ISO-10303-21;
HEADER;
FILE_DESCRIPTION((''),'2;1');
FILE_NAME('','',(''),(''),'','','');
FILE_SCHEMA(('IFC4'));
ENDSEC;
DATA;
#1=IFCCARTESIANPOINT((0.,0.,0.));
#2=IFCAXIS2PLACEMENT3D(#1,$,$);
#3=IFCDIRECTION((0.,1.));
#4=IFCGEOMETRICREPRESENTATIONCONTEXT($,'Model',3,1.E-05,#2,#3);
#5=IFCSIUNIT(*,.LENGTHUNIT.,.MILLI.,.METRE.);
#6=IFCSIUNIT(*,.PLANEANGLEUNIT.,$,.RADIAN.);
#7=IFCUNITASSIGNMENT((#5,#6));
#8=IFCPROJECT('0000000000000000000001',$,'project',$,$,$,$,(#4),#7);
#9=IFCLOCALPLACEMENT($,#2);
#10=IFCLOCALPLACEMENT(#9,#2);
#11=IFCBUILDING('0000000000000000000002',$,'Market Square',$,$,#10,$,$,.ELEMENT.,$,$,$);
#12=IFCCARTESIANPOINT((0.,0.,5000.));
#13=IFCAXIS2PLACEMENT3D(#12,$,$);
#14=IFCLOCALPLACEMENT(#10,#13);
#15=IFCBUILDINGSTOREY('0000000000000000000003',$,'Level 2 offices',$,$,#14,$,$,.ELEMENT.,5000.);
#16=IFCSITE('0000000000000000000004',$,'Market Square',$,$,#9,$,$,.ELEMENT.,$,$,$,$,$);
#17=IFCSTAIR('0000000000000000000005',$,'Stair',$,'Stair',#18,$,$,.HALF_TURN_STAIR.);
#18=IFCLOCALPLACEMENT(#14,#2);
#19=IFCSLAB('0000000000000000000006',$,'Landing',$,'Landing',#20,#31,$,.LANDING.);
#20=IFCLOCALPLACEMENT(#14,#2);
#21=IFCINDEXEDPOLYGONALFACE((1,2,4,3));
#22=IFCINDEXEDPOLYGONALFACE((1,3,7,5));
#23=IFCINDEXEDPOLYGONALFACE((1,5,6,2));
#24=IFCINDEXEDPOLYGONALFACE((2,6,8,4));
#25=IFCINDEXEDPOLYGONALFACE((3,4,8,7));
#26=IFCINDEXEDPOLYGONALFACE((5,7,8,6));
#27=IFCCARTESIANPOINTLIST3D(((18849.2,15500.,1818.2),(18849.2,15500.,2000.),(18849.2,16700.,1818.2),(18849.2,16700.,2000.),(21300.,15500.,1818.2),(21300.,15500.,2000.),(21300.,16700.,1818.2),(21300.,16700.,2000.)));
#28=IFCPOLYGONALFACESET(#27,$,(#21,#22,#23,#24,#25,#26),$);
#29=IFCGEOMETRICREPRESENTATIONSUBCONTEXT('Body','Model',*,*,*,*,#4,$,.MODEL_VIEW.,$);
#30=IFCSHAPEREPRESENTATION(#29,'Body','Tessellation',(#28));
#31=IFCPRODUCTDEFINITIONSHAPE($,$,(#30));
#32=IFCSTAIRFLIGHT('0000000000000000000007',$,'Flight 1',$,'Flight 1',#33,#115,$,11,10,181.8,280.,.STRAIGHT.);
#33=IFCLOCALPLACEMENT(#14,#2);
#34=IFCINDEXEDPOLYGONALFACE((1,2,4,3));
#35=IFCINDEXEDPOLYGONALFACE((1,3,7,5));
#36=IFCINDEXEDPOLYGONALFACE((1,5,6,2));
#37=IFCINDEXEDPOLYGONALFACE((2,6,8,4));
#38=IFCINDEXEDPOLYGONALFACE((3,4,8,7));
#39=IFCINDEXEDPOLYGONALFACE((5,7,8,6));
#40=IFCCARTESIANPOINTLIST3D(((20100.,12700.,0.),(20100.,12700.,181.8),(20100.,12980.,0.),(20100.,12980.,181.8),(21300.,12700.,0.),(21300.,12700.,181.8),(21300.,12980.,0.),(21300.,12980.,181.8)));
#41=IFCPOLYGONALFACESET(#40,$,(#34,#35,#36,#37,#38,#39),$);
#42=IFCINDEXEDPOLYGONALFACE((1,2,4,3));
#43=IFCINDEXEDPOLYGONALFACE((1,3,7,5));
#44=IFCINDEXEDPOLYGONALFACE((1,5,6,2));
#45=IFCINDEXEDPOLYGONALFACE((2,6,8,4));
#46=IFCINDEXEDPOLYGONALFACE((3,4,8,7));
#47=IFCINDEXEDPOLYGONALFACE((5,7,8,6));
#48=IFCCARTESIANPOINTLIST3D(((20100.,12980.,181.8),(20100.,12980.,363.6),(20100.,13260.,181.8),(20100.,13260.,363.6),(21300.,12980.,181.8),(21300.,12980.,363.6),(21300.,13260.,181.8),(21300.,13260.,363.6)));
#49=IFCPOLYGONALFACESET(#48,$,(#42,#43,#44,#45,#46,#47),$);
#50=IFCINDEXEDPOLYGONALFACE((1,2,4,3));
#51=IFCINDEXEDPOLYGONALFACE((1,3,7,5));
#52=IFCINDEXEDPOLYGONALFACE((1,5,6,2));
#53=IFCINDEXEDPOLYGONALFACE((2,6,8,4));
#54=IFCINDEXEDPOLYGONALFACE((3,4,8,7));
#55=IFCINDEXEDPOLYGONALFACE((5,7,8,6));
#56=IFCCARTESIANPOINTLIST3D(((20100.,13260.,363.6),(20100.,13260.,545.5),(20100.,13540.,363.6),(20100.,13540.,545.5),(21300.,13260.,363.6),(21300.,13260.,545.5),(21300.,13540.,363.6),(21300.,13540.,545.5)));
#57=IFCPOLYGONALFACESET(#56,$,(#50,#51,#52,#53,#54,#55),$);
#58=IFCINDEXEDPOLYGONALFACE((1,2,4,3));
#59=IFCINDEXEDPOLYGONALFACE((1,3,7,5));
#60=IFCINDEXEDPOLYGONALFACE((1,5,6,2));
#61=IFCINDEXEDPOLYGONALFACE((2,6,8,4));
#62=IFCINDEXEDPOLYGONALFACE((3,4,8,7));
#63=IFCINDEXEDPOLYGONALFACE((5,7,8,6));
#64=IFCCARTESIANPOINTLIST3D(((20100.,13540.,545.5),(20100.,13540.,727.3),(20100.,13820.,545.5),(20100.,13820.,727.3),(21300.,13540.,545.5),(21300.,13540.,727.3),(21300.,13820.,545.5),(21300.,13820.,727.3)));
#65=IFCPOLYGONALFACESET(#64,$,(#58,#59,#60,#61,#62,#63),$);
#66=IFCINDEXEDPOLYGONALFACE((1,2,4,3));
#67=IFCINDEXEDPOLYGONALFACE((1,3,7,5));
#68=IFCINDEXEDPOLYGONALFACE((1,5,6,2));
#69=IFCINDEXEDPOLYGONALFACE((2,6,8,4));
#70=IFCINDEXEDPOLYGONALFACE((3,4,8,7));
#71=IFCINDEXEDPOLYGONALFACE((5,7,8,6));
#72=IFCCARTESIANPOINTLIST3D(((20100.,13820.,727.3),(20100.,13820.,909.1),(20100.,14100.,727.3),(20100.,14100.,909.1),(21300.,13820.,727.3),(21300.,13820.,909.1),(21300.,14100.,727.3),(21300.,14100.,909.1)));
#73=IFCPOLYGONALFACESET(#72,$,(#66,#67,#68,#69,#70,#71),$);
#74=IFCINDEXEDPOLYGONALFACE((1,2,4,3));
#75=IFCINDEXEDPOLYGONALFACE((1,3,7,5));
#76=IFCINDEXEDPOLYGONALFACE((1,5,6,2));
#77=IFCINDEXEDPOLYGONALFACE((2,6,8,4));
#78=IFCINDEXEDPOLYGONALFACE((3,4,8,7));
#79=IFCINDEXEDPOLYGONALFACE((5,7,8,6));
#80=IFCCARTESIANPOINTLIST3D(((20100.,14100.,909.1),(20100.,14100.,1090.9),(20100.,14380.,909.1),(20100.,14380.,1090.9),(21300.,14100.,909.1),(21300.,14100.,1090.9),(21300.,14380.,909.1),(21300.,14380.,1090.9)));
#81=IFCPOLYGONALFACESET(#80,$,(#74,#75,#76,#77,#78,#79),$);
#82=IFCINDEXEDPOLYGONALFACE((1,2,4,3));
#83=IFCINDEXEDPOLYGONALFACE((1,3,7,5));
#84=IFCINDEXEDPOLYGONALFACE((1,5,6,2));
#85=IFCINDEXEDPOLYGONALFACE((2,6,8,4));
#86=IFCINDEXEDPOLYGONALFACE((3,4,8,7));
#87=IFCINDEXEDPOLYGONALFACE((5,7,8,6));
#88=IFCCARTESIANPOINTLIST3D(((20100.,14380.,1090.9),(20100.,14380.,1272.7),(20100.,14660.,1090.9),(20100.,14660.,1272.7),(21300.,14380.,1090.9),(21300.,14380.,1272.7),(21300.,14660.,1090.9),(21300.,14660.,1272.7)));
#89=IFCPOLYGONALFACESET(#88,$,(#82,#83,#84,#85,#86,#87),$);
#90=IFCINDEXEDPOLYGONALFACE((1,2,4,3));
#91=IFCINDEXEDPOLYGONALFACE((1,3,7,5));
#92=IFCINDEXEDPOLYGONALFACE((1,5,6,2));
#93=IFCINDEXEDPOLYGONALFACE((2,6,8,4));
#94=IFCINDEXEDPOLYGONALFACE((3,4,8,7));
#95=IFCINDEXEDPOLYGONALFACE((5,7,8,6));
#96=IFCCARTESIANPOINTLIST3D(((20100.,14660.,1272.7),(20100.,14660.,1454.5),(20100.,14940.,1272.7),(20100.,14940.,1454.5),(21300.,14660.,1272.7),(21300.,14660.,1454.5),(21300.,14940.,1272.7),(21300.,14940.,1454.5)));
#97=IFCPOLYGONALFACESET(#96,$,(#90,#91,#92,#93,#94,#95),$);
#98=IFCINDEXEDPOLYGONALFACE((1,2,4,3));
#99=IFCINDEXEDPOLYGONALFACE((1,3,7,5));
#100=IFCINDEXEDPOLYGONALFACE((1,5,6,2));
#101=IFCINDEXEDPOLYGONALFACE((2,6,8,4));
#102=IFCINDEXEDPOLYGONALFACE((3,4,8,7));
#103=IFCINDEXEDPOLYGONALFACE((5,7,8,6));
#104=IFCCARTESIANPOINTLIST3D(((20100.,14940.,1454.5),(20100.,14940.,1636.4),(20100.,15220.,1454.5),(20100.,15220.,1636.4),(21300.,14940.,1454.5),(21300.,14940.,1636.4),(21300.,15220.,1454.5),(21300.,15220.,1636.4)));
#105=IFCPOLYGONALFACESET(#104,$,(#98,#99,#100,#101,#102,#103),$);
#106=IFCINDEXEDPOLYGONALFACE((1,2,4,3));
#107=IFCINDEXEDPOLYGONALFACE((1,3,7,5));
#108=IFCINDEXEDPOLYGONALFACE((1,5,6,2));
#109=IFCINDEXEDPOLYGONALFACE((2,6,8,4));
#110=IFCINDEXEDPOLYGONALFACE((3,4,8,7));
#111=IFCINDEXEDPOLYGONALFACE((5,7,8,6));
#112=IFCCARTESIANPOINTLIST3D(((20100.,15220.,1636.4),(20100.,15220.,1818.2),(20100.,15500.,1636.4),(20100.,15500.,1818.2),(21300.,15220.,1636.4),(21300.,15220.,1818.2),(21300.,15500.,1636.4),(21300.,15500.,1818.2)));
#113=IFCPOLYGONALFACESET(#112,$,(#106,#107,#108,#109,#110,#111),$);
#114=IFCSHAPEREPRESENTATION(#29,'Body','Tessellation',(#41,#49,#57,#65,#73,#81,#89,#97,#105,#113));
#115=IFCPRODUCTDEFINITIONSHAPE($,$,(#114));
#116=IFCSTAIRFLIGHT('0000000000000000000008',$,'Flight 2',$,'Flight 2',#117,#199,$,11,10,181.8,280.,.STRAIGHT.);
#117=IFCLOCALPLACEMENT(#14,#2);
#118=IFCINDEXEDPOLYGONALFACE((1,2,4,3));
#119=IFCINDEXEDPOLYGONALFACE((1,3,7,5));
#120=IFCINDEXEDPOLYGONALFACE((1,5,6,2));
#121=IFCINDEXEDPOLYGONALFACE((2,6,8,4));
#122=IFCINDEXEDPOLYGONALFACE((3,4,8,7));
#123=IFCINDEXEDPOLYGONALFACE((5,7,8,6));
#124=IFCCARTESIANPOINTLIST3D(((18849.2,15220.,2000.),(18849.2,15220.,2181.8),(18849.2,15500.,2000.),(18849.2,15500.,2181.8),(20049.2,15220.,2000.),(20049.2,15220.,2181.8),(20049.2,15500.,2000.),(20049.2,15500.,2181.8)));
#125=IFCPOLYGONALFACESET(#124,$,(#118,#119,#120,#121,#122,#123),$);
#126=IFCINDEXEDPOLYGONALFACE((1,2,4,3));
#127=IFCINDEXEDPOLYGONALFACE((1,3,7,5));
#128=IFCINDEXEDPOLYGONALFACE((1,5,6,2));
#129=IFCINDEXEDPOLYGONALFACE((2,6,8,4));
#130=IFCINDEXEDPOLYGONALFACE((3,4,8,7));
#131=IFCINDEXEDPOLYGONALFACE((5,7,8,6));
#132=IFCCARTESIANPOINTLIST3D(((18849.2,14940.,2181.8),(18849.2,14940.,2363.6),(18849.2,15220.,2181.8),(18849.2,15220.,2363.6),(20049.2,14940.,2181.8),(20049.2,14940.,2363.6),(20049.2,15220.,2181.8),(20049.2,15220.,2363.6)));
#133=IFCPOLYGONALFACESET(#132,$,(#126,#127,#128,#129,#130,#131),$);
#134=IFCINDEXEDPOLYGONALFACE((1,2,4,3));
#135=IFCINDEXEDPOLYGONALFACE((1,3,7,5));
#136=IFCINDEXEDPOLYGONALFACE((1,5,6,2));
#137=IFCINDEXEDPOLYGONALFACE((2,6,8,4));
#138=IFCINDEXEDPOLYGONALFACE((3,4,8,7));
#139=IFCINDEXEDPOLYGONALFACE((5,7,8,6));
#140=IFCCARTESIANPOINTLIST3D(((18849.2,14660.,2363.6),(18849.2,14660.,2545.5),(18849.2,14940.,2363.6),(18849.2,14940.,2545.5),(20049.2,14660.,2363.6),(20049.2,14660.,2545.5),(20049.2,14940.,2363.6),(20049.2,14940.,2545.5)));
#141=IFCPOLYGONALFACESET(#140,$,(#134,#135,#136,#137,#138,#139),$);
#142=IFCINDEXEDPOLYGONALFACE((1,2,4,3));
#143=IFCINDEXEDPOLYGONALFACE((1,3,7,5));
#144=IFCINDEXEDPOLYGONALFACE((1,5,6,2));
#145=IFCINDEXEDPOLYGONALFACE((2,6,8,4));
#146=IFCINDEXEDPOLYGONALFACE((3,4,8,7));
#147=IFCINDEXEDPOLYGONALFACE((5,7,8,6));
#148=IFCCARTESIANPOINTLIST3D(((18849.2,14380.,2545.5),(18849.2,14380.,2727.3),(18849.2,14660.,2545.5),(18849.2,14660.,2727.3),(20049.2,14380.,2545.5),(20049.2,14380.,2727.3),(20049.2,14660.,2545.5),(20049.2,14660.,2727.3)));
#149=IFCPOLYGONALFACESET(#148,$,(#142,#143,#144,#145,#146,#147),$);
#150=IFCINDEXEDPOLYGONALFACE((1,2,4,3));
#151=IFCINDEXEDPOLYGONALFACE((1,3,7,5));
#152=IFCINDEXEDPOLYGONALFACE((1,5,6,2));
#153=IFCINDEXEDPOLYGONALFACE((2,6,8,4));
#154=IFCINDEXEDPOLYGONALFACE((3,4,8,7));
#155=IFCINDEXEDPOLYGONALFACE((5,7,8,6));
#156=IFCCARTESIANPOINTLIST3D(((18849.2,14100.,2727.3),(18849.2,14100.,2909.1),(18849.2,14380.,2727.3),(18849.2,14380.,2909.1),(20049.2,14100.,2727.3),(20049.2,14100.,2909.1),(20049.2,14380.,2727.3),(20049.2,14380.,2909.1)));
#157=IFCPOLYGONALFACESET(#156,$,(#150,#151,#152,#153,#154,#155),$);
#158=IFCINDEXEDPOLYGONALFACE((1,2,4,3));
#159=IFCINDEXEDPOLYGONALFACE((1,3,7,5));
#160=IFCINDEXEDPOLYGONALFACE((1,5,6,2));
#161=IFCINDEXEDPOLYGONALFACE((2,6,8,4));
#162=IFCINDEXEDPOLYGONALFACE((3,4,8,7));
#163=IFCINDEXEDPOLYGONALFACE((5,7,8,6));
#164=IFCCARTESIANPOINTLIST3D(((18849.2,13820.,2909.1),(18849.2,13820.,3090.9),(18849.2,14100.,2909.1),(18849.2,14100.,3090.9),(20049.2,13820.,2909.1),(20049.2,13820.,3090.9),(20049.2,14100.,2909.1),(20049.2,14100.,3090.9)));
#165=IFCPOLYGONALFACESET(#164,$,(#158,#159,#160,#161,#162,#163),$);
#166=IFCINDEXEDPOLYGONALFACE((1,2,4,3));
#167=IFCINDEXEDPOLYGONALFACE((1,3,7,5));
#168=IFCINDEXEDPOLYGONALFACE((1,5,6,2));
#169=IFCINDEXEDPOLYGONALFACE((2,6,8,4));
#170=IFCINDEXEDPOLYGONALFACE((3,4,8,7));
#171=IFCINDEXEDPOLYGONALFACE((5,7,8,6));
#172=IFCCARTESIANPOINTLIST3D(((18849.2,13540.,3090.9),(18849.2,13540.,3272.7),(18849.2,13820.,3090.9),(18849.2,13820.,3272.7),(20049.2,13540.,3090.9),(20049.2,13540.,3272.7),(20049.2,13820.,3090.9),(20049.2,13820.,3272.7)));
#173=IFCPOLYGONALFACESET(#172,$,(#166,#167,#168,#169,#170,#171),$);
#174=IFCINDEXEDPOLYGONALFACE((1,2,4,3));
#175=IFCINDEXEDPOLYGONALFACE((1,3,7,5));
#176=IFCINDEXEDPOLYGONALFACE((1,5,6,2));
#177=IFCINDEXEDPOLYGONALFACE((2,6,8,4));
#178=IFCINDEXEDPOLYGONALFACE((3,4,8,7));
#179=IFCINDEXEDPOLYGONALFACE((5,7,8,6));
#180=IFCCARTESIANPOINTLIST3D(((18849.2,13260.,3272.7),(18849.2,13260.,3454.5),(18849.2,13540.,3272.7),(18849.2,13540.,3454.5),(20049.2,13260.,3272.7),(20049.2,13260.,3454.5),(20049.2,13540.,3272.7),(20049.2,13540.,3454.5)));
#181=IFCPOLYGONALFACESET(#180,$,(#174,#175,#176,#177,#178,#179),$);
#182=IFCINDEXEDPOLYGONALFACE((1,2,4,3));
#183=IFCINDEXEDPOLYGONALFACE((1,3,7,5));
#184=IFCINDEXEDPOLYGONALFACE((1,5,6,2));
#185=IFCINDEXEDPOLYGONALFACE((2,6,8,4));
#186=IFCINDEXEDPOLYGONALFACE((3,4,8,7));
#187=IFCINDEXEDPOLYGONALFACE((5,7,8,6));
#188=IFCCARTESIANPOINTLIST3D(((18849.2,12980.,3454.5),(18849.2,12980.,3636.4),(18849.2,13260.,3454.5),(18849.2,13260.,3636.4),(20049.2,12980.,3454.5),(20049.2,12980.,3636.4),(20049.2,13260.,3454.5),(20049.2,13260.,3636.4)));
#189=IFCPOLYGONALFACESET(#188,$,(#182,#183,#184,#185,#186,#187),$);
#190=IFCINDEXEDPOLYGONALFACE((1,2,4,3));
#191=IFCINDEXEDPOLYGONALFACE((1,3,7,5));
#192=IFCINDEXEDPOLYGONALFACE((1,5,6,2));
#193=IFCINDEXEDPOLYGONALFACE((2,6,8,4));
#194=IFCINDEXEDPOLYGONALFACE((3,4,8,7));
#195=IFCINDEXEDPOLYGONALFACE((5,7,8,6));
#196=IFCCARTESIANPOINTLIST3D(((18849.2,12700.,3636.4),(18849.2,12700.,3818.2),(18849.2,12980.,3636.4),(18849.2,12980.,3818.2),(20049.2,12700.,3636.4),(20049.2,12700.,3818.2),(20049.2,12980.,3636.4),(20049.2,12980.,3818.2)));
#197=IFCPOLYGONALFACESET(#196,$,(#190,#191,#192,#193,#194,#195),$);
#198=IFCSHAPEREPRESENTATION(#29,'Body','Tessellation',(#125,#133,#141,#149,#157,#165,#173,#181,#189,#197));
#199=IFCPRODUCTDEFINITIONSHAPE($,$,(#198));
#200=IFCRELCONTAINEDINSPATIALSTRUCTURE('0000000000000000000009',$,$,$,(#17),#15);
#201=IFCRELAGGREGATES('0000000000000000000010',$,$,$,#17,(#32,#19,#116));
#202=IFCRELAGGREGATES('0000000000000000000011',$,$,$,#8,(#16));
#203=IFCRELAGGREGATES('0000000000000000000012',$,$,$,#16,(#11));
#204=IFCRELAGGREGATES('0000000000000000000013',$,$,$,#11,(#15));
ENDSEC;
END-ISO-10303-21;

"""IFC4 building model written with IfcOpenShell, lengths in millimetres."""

from ifc_helpers import new_model, si_unit, direction, frame, origin, origin_with_axes, place, context, subcontext, project, spatial, polyline, outline, extrude, element, aggregate, save


model = new_model("IFC4")

# Units and contexts
model_context = context("Model", 3, precision=1e-05, world=origin(), true_north=direction((0.0, 1.0)))
body_context = subcontext(model_context, "Body", "Model", "MODEL_VIEW")
ifc_project = project(units=[si_unit("LENGTHUNIT", "METRE", prefix="MILLI"), si_unit("PLANEANGLEUNIT", "RADIAN")], contexts=[model_context])

# Site, building, storey
site_placement = place(None, origin())
site = spatial("IfcSite", under=ifc_project, at=site_placement, Name="Market Square", CompositionType="ELEMENT")
building_placement = place(site_placement, origin())
building = spatial("IfcBuilding", under=site, at=building_placement, Name="Market Square", CompositionType="ELEMENT")
storey_placement = place(building_placement, frame((0.0, 0.0, 5000.0)))
storey = spatial("IfcBuildingStorey", under=building, at=storey_placement, Name="Level 2 offices", CompositionType="ELEMENT", Elevation=5000.0)

# Stair, slab
stair_placement = place(storey_placement, origin_with_axes())
stair = element("IfcStair", 1, at=stair_placement, inside=storey, Name="Stair", ObjectType="Stair", PredefinedType="HALF_TURN_STAIR")
slab_placement = place(storey_placement, origin_with_axes())
slab = element("IfcSlab", 2, at=slab_placement, Name="Landing", ObjectType="Landing", PredefinedType="LANDING", context=body_context, shape_type="SweptSolid", body=[
    extrude(outline(polyline([(21300.0, 15500.0), (21300.0, 16700.0), (18849.2, 16700.0), (18849.2, 15500.0), (21300.0, 15500.0)])), frame((0.0, 0.0, 1818.2)), (0.0, 0.0, 1.0), 181.8),
])

# Stair flights
stair_flight_1_placement = place(storey_placement, origin_with_axes())
stair_flight_1 = element("IfcStairFlight", 3, at=stair_flight_1_placement, Name="Flight 1", ObjectType="Flight 1", NumberOfRisers=11, NumberOfTreads=10, PredefinedType="STRAIGHT", RiserHeight=181.8, TreadLength=280.0, context=body_context, shape_type="SweptSolid", body=[
    extrude(outline(polyline([(21300.0, 12700.0), (21300.0, 12980.0), (20100.0, 12980.0), (20100.0, 12700.0), (21300.0, 12700.0)])), origin(), (0.0, 0.0, 1.0), 181.8),
    extrude(outline(polyline([(21300.0, 12980.0), (21300.0, 13260.0), (20100.0, 13260.0), (20100.0, 12980.0), (21300.0, 12980.0)])), frame((0.0, 0.0, 181.8)), (0.0, 0.0, 1.0), 181.8),
    extrude(outline(polyline([(21300.0, 13260.0), (21300.0, 13540.0), (20100.0, 13540.0), (20100.0, 13260.0), (21300.0, 13260.0)])), frame((0.0, 0.0, 363.6)), (0.0, 0.0, 1.0), 181.8),
    extrude(outline(polyline([(21300.0, 13540.0), (21300.0, 13820.0), (20100.0, 13820.0), (20100.0, 13540.0), (21300.0, 13540.0)])), frame((0.0, 0.0, 545.5)), (0.0, 0.0, 1.0), 181.8),
    extrude(outline(polyline([(21300.0, 13820.0), (21300.0, 14100.0), (20100.0, 14100.0), (20100.0, 13820.0), (21300.0, 13820.0)])), frame((0.0, 0.0, 727.3)), (0.0, 0.0, 1.0), 181.8),
    extrude(outline(polyline([(21300.0, 14100.0), (21300.0, 14380.0), (20100.0, 14380.0), (20100.0, 14100.0), (21300.0, 14100.0)])), frame((0.0, 0.0, 909.1)), (0.0, 0.0, 1.0), 181.8),
    extrude(outline(polyline([(21300.0, 14380.0), (21300.0, 14660.0), (20100.0, 14660.0), (20100.0, 14380.0), (21300.0, 14380.0)])), frame((0.0, 0.0, 1090.9)), (0.0, 0.0, 1.0), 181.8),
    extrude(outline(polyline([(21300.0, 14660.0), (21300.0, 14940.0), (20100.0, 14940.0), (20100.0, 14660.0), (21300.0, 14660.0)])), frame((0.0, 0.0, 1272.7)), (0.0, 0.0, 1.0), 181.8),
    extrude(outline(polyline([(21300.0, 14940.0), (21300.0, 15220.0), (20100.0, 15220.0), (20100.0, 14940.0), (21300.0, 14940.0)])), frame((0.0, 0.0, 1454.5)), (0.0, 0.0, 1.0), 181.8),
    extrude(outline(polyline([(21300.0, 15220.0), (21300.0, 15500.0), (20100.0, 15500.0), (20100.0, 15220.0), (21300.0, 15220.0)])), frame((0.0, 0.0, 1636.4)), (0.0, 0.0, 1.0), 181.8),
])
stair_flight_2_placement = place(storey_placement, origin_with_axes())
stair_flight_2 = element("IfcStairFlight", 4, at=stair_flight_2_placement, Name="Flight 2", ObjectType="Flight 2", NumberOfRisers=11, NumberOfTreads=10, PredefinedType="STRAIGHT", RiserHeight=181.8, TreadLength=280.0, context=body_context, shape_type="SweptSolid", body=[
    extrude(outline(polyline([(20049.2, 15220.0), (20049.2, 15500.0), (18849.2, 15500.0), (18849.2, 15220.0), (20049.2, 15220.0)])), frame((0.0, 0.0, 2000.0)), (0.0, 0.0, 1.0), 181.8),
    extrude(outline(polyline([(20049.2, 14940.0), (20049.2, 15220.0), (18849.2, 15220.0), (18849.2, 14940.0), (20049.2, 14940.0)])), frame((0.0, 0.0, 2181.8)), (0.0, 0.0, 1.0), 181.8),
    extrude(outline(polyline([(20049.2, 14660.0), (20049.2, 14940.0), (18849.2, 14940.0), (18849.2, 14660.0), (20049.2, 14660.0)])), frame((0.0, 0.0, 2363.6)), (0.0, 0.0, 1.0), 181.8),
    extrude(outline(polyline([(20049.2, 14380.0), (20049.2, 14660.0), (18849.2, 14660.0), (18849.2, 14380.0), (20049.2, 14380.0)])), frame((0.0, 0.0, 2545.5)), (0.0, 0.0, 1.0), 181.8),
    extrude(outline(polyline([(20049.2, 14100.0), (20049.2, 14380.0), (18849.2, 14380.0), (18849.2, 14100.0), (20049.2, 14100.0)])), frame((0.0, 0.0, 2727.3)), (0.0, 0.0, 1.0), 181.8),
    extrude(outline(polyline([(20049.2, 13820.0), (20049.2, 14100.0), (18849.2, 14100.0), (18849.2, 13820.0), (20049.2, 13820.0)])), frame((0.0, 0.0, 2909.1)), (0.0, 0.0, 1.0), 181.8),
    extrude(outline(polyline([(20049.2, 13540.0), (20049.2, 13820.0), (18849.2, 13820.0), (18849.2, 13540.0), (20049.2, 13540.0)])), frame((0.0, 0.0, 3090.9)), (0.0, 0.0, 1.0), 181.8),
    extrude(outline(polyline([(20049.2, 13260.0), (20049.2, 13540.0), (18849.2, 13540.0), (18849.2, 13260.0), (20049.2, 13260.0)])), frame((0.0, 0.0, 3272.7)), (0.0, 0.0, 1.0), 181.8),
    extrude(outline(polyline([(20049.2, 12980.0), (20049.2, 13260.0), (18849.2, 13260.0), (18849.2, 12980.0), (20049.2, 12980.0)])), frame((0.0, 0.0, 3454.5)), (0.0, 0.0, 1.0), 181.8),
    extrude(outline(polyline([(20049.2, 12700.0), (20049.2, 12980.0), (18849.2, 12980.0), (18849.2, 12700.0), (20049.2, 12700.0)])), frame((0.0, 0.0, 3636.4)), (0.0, 0.0, 1.0), 181.8),
])
aggregate(stair, [stair_flight_1, slab, stair_flight_2])

save(model, "model.ifc")
